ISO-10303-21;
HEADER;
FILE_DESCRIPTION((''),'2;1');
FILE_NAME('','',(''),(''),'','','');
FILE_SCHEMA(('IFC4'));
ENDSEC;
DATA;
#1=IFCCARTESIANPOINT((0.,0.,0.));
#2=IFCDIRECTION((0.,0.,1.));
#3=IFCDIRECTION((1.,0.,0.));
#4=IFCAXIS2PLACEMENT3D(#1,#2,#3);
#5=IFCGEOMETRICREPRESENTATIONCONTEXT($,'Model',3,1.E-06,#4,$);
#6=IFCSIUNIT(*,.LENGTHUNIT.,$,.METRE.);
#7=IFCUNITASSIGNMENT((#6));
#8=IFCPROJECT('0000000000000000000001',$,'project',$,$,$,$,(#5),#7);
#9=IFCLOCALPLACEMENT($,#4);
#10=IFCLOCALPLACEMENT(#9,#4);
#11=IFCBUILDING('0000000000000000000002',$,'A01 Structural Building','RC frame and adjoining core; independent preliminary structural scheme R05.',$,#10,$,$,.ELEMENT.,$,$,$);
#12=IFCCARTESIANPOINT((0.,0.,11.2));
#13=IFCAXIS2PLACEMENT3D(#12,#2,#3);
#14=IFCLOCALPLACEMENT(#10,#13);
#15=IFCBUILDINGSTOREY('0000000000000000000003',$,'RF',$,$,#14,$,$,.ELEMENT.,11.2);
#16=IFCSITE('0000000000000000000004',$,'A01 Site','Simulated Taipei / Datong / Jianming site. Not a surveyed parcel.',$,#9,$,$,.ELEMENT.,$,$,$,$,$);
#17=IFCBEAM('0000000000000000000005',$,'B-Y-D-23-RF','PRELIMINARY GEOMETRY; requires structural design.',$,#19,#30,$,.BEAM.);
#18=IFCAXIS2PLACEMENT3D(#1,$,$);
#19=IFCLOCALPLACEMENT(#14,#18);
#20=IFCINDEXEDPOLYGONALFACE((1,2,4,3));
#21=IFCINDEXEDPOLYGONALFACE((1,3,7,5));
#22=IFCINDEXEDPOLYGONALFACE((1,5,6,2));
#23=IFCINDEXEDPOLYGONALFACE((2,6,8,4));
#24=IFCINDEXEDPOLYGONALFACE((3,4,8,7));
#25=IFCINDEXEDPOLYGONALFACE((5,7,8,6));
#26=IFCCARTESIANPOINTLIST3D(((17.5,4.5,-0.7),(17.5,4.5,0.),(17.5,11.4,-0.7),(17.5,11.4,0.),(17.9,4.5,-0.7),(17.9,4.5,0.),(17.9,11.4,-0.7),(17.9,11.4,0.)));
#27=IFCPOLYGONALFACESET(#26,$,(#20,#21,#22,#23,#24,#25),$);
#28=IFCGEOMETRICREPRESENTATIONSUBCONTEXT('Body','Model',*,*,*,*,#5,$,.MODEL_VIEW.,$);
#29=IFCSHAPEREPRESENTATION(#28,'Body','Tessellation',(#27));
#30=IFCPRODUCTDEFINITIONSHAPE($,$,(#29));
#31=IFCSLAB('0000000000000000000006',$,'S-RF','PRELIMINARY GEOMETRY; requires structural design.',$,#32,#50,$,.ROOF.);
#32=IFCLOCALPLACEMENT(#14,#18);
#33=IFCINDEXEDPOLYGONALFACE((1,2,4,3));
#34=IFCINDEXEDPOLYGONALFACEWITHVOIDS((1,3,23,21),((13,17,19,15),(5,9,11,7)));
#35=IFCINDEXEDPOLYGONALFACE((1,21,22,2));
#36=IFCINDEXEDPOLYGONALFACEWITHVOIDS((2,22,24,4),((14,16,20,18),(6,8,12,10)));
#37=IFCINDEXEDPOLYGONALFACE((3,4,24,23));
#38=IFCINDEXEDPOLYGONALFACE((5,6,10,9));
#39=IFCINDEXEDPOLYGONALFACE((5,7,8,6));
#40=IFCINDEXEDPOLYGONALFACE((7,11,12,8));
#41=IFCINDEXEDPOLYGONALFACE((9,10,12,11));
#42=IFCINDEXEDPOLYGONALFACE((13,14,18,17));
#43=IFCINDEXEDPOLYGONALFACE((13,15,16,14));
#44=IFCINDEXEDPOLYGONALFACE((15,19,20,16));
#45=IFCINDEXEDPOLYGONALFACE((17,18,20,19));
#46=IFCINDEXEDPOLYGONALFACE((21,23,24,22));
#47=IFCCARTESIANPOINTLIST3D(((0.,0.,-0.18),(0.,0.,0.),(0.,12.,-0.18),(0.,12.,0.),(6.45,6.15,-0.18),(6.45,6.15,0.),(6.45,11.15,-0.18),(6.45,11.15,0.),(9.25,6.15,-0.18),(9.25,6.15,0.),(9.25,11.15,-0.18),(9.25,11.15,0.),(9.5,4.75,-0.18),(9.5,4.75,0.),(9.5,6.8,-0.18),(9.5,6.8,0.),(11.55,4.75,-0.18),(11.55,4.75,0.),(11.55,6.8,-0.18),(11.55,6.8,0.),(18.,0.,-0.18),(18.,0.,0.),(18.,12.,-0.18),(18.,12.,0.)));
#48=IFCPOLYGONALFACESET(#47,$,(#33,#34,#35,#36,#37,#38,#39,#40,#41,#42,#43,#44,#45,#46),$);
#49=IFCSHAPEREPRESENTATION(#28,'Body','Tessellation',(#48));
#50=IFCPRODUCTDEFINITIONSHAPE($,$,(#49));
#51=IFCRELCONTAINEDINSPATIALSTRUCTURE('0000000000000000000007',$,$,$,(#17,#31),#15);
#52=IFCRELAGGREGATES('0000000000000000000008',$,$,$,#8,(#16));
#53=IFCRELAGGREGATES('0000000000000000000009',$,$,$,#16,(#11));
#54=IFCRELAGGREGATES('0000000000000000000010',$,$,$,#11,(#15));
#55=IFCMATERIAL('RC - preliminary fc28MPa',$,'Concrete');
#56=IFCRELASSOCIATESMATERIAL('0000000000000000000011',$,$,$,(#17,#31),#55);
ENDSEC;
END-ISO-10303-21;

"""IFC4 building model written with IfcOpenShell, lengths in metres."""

from ifc_helpers import new_model, si_unit, frame, origin_with_axes, place, context, subcontext, project, spatial, rectangle, extrude, material, element, save


model = new_model("IFC4")

# Units and contexts
model_context = context("Model", 3, precision=1e-06, world=origin_with_axes())
body_context = subcontext(model_context, "Body", "Model", "MODEL_VIEW")
ifc_project = project(units=[si_unit("LENGTHUNIT", "METRE")], contexts=[model_context])

# Site, building, storey
site_placement = place(None, origin_with_axes())
site = spatial("IfcSite", under=ifc_project, at=site_placement, Name="A01 Site", Description="Simulated Taipei / Datong / Jianming site. Not a surveyed parcel.", CompositionType="ELEMENT")
building_placement = place(site_placement, origin_with_axes())
building = spatial("IfcBuilding", under=site, at=building_placement, Name="A01 Structural Building", Description="RC frame and adjoining core; independent preliminary structural scheme R05.", CompositionType="ELEMENT")
storey_placement = place(building_placement, frame((0.0, 0.0, 11.2), z_axis=(0.0, 0.0, 1.0), x_axis=(1.0, 0.0, 0.0)))
storey = spatial("IfcBuildingStorey", under=building, at=storey_placement, Name="RF", CompositionType="ELEMENT", Elevation=11.2)

# Beam
ifc_material = material(Name="RC - preliminary fc28MPa", Category="Concrete")
beam_1_placement = place(storey_placement, frame((17.7, 7.95, -0.7), z_axis=(0.0, 0.0, 1.0), x_axis=(1.0, 0.0, 0.0)))
element("IfcBeam", 1, at=beam_1_placement, inside=storey, material=ifc_material, Name="B-Y-D-23-RF", Description="PRELIMINARY GEOMETRY; requires structural design.", PredefinedType="BEAM", context=body_context, shape_type="SweptSolid", body=[
    extrude(rectangle(XDim=0.4, YDim=6.9), origin_with_axes(), (0.0, 0.0, 1.0), 0.7),
])

# Slab, openings
slab_placement = place(storey_placement, frame((9.0, 6.0, -0.18), z_axis=(0.0, 0.0, 1.0), x_axis=(1.0, 0.0, 0.0)))
slab = element("IfcSlab", 2, at=slab_placement, inside=storey, material=ifc_material, Name="S-RF", Description="PRELIMINARY GEOMETRY; requires structural design.", PredefinedType="ROOF", context=body_context, shape_type="SweptSolid", body=[
    extrude(rectangle(XDim=18.0, YDim=12.0), origin_with_axes(), (0.0, 0.0, 1.0), 0.18),
])
opening_1_placement = place(storey_placement, frame((10.525, 5.775, -0.23), z_axis=(0.0, 0.0, 1.0), x_axis=(1.0, 0.0, 0.0)))
element("IfcOpeningElement", 3, at=opening_1_placement, cuts=slab, PredefinedType="OPENING", context=body_context, shape_type="SweptSolid", body=[
    extrude(rectangle(XDim=2.05, YDim=2.05), origin_with_axes(), (0.0, 0.0, 1.0), 0.28),
])
opening_2_placement = place(storey_placement, frame((7.85, 8.65, -0.23), z_axis=(0.0, 0.0, 1.0), x_axis=(1.0, 0.0, 0.0)))
element("IfcOpeningElement", 4, at=opening_2_placement, cuts=slab, PredefinedType="OPENING", context=body_context, shape_type="SweptSolid", body=[
    extrude(rectangle(XDim=2.8, YDim=5.0), origin_with_axes(), (0.0, 0.0, 1.0), 0.28),
])

save(model, "model.ifc")
